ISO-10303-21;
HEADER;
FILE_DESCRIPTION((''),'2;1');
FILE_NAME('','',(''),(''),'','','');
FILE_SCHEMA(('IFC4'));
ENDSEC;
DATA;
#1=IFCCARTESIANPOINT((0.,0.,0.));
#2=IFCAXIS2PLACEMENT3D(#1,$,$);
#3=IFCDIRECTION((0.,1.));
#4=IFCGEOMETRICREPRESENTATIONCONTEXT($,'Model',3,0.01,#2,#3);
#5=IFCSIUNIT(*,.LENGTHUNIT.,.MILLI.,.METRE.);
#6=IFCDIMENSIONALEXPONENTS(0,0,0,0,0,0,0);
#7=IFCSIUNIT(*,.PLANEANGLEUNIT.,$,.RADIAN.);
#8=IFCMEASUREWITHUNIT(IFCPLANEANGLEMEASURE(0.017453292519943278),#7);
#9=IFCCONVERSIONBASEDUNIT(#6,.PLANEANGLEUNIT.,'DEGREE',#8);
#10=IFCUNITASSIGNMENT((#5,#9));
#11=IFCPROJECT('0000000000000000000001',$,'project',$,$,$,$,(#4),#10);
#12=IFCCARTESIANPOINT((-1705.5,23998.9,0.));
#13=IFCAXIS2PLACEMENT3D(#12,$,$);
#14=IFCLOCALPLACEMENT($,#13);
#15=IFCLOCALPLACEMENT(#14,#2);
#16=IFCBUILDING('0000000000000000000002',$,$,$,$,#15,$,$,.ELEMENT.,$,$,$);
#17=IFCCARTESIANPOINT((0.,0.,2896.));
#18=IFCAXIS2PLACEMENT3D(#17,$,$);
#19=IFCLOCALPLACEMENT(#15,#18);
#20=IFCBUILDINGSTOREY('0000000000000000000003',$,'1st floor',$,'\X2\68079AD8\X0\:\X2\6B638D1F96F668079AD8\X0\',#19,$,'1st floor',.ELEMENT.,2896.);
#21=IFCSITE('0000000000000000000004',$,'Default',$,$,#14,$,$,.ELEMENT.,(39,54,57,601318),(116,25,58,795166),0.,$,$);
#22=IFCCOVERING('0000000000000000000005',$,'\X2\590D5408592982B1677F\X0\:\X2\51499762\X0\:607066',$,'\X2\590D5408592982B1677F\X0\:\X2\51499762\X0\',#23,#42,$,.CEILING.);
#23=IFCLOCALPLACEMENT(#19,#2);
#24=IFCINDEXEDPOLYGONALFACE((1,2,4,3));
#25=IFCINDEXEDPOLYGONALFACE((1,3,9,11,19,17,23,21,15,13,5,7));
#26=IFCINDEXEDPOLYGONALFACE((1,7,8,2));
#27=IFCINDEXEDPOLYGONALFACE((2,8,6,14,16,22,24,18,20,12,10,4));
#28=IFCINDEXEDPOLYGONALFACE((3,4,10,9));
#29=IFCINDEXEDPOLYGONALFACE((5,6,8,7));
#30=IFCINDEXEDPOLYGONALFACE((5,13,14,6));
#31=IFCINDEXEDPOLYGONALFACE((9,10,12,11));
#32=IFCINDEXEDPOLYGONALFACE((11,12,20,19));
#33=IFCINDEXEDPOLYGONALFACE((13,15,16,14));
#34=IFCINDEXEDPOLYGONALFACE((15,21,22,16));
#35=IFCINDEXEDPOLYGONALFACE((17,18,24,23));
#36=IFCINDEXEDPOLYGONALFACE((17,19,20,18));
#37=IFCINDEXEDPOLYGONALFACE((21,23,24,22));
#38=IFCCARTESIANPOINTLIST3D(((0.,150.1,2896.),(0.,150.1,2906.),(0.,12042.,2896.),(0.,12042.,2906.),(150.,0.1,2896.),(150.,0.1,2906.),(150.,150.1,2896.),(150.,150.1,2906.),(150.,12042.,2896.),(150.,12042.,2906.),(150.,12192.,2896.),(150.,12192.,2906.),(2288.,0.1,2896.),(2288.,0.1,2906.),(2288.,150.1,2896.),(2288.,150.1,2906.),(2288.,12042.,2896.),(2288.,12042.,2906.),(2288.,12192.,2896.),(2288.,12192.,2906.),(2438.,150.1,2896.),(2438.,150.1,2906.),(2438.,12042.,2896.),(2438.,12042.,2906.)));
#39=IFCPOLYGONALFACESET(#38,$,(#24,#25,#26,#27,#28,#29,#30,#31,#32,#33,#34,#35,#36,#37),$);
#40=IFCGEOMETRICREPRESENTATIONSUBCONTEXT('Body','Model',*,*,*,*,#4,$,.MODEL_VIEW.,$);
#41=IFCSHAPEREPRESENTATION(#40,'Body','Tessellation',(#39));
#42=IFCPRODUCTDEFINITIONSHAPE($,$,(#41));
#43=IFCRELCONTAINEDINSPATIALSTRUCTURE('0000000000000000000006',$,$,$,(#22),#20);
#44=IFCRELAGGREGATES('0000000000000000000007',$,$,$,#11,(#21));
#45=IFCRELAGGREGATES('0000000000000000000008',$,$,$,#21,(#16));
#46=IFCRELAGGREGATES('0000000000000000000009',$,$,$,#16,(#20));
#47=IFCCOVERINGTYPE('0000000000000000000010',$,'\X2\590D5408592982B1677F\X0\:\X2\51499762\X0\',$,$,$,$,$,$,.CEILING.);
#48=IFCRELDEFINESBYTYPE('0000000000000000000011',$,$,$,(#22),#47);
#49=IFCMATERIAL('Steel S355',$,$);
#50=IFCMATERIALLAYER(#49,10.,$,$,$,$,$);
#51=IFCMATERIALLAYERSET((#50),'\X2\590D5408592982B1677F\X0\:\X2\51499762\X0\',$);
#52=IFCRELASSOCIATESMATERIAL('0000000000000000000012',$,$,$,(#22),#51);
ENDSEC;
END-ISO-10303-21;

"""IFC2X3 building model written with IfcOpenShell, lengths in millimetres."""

from ifc_helpers import new_model, entity, si_unit, converted_unit, direction, frame, origin, place, context, subcontext, project, spatial, polyline, outline, extrude, material, layer, layer_set, layer_usage, type_object, element, save


model = new_model("IFC2X3")

# Units and contexts
model_context = context("Model", 3, precision=0.01, world=origin(), true_north=direction((0.0, 1.0)))
body_context = subcontext(model_context, "Body", "Model", "MODEL_VIEW")
ifc_project = project(units=[si_unit("LENGTHUNIT", "METRE", prefix="MILLI"), converted_unit("PLANEANGLEUNIT", "DEGREE", entity("IfcPlaneAngleMeasure", 0.017453292519943278), si_unit("PLANEANGLEUNIT", "RADIAN"), dimensions=[0, 0, 0, 0, 0, 0, 0])], contexts=[model_context])

# Site, building, storey
site_placement = place(None, frame((-1705.5, 23998.9, 0.0)))
site = spatial("IfcSite", under=ifc_project, at=site_placement, Name="Default", CompositionType="ELEMENT", RefLatitude=(39, 54, 57, 601318), RefLongitude=(116, 25, 58, 795166), RefElevation=0.0)
building_placement = place(site_placement, origin())
building = spatial("IfcBuilding", under=site, at=building_placement, CompositionType="ELEMENT")
storey_placement = place(building_placement, frame((0.0, 0.0, 2896.0)))
storey = spatial("IfcBuildingStorey", under=building, at=storey_placement, Name="1st floor", ObjectType="标高:正负零标高", LongName="1st floor", CompositionType="ELEMENT", Elevation=2896.0)

# Shared definitions
ifc_material_1 = material(Name="Steel S355")

# Covering
ifc_layer_1 = layer(ifc_material_1, 10.0)
ifc_layer_set_1 = layer_set([ifc_layer_1], Name="复合天花板:光面")
ifc_layer_usage_1 = layer_usage(ifc_layer_set_1, "AXIS3", "NEGATIVE", 10.0)
covering_type = type_object("IfcCoveringType", Name="复合天花板:光面", PredefinedType="CEILING")
covering_placement = place(storey_placement, origin())
element("IfcCovering", 1, at=covering_placement, inside=storey, type_object=covering_type, material=ifc_layer_usage_1, Name="复合天花板:光面:607066", ObjectType="复合天花板:光面", PredefinedType="CEILING", context=body_context, shape_type="SweptSolid", body=[
    extrude(outline(polyline([(5946.0, -1069.0), (6096.0, -1069.0), (6096.0, 1069.0), (5945.9, 1069.0), (5945.9, 1219.0), (-5946.0, 1219.0), (-5946.0, 1069.0), (-6096.0, 1069.0), (-6096.0, -1069.0), (-5946.0, -1069.0), (-5946.0, -1219.0), (5946.0, -1219.0), (5946.0, -1069.0)])), frame((1219.0, 6096.0, 2896.0), z_axis=(0.0, 0.0, 1.0), x_axis=(0.0, 1.0, 0.0)), (0.0, 0.0, 1.0), 10.0),
])

save(model, "model.ifc")
